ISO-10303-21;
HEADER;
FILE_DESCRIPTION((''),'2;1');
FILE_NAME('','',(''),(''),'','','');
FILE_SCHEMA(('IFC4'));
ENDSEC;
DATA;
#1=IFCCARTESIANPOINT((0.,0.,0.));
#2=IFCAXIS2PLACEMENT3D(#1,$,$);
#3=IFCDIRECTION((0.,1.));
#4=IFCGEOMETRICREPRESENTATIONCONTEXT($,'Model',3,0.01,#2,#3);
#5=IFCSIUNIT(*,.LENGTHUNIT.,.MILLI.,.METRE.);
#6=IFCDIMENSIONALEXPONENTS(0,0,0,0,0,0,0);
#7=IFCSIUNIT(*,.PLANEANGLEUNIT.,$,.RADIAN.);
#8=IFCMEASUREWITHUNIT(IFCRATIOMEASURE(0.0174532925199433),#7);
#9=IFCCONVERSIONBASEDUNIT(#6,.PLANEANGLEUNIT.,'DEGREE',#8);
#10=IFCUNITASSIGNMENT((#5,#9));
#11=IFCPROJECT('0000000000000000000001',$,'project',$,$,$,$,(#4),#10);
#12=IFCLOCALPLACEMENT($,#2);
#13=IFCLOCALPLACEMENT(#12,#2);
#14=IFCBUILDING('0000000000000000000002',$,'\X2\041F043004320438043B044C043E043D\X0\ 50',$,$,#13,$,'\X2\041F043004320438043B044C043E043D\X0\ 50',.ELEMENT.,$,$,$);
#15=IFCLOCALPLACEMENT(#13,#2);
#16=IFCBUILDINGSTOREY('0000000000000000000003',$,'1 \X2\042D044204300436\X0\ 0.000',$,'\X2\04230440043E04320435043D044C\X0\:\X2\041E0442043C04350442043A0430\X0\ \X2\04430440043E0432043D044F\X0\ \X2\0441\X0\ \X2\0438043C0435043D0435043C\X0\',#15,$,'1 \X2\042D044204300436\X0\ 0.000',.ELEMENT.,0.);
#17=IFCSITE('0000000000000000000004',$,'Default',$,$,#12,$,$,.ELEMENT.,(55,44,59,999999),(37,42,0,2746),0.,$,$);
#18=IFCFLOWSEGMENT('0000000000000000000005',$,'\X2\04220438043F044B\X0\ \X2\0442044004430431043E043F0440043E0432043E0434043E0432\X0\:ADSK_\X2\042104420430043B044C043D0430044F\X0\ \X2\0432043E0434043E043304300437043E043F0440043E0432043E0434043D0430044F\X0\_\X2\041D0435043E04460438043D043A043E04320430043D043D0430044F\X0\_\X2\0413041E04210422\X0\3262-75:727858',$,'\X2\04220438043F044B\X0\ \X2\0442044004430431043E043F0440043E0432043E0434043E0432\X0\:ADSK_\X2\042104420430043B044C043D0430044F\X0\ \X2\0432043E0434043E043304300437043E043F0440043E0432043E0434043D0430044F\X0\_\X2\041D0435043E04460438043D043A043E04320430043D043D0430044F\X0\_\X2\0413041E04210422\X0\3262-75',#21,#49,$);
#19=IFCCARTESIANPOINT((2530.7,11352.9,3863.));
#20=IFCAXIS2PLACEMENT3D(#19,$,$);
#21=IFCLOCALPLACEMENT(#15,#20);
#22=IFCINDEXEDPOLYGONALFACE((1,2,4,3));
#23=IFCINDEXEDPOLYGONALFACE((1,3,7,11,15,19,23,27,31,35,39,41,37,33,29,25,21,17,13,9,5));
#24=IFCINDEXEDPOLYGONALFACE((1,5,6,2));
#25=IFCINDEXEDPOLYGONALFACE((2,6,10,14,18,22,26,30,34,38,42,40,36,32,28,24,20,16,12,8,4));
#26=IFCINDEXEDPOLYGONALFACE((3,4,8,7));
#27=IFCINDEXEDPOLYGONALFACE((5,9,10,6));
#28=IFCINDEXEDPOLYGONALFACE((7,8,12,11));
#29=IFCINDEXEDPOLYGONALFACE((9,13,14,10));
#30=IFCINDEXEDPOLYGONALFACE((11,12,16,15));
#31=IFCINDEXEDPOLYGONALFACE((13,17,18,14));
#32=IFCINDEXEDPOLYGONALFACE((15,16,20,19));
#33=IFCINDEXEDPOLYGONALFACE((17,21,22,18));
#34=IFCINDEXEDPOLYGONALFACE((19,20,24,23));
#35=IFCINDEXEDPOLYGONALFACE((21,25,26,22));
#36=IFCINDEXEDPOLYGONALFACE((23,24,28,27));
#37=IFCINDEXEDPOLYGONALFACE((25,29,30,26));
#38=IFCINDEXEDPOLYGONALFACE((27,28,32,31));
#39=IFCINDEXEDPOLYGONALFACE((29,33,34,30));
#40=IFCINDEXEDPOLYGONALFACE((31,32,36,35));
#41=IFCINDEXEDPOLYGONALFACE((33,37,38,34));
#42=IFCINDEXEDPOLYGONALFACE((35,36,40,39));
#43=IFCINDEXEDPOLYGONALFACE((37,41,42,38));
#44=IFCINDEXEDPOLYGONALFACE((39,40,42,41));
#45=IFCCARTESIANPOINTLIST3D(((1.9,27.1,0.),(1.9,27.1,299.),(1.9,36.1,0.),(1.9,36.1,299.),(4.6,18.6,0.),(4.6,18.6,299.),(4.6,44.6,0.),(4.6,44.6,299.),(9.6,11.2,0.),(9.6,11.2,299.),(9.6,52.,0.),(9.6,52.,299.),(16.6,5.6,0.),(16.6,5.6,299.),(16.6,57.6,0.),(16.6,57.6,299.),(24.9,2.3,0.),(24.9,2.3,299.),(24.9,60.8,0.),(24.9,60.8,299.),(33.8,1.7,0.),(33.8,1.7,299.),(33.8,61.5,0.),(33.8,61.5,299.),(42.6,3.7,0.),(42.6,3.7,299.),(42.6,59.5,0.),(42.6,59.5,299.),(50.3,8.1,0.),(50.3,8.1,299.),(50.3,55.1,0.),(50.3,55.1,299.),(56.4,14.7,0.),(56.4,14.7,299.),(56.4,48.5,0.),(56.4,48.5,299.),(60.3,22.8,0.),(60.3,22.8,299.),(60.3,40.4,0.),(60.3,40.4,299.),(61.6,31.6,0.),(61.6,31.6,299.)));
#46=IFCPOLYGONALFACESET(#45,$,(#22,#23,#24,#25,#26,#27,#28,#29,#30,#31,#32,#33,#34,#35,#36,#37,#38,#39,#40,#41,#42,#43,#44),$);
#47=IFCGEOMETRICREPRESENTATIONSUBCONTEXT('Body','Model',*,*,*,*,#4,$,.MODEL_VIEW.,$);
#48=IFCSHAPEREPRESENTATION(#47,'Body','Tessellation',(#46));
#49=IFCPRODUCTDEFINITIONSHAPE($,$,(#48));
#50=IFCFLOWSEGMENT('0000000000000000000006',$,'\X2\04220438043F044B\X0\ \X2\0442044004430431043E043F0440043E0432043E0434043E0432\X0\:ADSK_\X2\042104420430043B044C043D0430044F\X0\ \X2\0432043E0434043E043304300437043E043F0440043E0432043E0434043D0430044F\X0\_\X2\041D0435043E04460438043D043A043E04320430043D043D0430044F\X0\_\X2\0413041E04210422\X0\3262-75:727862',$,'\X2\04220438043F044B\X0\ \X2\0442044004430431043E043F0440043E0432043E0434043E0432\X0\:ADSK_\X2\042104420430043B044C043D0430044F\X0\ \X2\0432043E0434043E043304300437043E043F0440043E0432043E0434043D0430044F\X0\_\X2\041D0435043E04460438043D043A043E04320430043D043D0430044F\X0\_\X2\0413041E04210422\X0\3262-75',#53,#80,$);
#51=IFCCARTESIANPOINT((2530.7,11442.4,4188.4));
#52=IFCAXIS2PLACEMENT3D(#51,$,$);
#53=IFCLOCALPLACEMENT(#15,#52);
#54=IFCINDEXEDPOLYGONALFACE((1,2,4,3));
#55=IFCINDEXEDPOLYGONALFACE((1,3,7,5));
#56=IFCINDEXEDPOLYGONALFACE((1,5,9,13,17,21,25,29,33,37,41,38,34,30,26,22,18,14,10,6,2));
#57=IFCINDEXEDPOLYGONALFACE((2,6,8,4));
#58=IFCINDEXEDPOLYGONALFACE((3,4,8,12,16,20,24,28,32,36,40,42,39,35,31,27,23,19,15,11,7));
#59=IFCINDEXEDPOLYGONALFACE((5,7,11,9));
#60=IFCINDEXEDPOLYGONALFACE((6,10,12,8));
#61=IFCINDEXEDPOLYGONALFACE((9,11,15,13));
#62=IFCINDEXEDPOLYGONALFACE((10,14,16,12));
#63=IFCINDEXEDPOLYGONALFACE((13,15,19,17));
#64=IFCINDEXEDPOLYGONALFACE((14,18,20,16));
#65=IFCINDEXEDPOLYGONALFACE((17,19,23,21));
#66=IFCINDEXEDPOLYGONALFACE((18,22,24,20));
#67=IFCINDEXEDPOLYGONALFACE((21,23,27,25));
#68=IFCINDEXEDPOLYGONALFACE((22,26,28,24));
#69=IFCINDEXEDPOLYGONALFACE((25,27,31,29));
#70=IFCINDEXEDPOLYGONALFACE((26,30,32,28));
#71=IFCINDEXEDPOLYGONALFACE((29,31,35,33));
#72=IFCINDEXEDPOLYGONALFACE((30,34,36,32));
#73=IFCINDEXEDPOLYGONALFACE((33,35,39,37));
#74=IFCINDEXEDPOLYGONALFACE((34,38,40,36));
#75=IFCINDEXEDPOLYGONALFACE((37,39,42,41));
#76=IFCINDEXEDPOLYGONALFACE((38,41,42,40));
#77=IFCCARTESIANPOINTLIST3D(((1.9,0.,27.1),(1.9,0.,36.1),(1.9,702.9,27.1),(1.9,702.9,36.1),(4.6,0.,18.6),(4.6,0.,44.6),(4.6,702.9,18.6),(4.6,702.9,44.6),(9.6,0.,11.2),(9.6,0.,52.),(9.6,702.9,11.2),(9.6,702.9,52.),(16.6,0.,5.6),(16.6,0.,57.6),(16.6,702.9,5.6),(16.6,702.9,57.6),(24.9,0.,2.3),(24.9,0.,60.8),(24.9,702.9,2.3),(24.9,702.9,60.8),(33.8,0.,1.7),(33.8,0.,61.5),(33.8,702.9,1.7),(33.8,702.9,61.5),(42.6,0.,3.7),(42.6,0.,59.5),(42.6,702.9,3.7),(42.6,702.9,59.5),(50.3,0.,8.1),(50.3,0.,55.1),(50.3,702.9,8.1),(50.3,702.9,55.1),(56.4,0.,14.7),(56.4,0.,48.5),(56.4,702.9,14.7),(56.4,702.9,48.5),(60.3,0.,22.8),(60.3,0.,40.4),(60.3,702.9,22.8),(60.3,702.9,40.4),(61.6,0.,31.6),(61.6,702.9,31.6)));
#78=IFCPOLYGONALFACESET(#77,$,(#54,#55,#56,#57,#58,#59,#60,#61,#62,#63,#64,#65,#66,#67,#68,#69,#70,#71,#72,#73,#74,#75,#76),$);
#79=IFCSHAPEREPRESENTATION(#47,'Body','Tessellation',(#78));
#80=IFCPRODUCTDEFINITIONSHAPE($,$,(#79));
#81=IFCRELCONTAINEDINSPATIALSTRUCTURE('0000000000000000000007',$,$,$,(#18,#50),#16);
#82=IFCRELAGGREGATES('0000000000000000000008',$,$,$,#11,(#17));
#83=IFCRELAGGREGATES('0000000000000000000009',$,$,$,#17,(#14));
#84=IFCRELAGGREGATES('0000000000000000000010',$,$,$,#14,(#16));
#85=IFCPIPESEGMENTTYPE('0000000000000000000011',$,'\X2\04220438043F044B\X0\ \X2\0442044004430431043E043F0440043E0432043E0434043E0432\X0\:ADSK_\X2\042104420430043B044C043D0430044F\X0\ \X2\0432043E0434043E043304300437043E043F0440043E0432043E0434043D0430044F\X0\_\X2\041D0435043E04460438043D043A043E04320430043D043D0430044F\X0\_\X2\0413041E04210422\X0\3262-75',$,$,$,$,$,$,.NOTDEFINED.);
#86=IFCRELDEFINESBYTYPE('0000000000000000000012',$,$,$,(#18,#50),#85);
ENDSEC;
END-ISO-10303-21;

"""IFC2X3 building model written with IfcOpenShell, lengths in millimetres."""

from ifc_helpers import new_model, entity, si_unit, converted_unit, direction, frame, origin, origin_2d_with_axis, place, context, subcontext, project, spatial, circle, extrude, type_object, element, save


model = new_model("IFC2X3")

# Units and contexts
model_context = context("Model", 3, precision=0.01, world=origin(), true_north=direction((0.0, 1.0)))
body_context = subcontext(model_context, "Body", "Model", "MODEL_VIEW")
ifc_project = project(units=[si_unit("LENGTHUNIT", "METRE", prefix="MILLI"), converted_unit("PLANEANGLEUNIT", "DEGREE", entity("IfcRatioMeasure", 0.0174532925199433), si_unit("PLANEANGLEUNIT", "RADIAN"), dimensions=[0, 0, 0, 0, 0, 0, 0])], contexts=[model_context])

# Site, building, storey
site_placement = place(None, origin())
site = spatial("IfcSite", under=ifc_project, at=site_placement, Name="Default", CompositionType="ELEMENT", RefLatitude=(55, 44, 59, 999999), RefLongitude=(37, 42, 0, 2746), RefElevation=0.0)
building_placement = place(site_placement, origin())
building = spatial("IfcBuilding", under=site, at=building_placement, Name="Павильон 50", LongName="Павильон 50", CompositionType="ELEMENT")
storey_placement = place(building_placement, origin())
storey = spatial("IfcBuildingStorey", under=building, at=storey_placement, Name="1 Этаж 0.000", ObjectType="Уровень:Отметка уровня с именем", LongName="1 Этаж 0.000", CompositionType="ELEMENT", Elevation=0.0)

# Flow segments
pipe_segment_type = type_object("IfcPipeSegmentType", Name="Типы трубопроводов:ADSK_Стальная водогазопроводная_Неоцинкованная_ГОСТ3262-75", PredefinedType="NOTDEFINED")
flow_segment_1_placement = place(storey_placement, frame((2530.7, 11352.9, 3863.0)))
element("IfcFlowSegment", 1, at=flow_segment_1_placement, inside=storey, type_object=pipe_segment_type, Name="Типы трубопроводов:ADSK_Стальная водогазопроводная_Неоцинкованная_ГОСТ3262-75:727858", ObjectType="Типы трубопроводов:ADSK_Стальная водогазопроводная_Неоцинкованная_ГОСТ3262-75", context=body_context, shape_type="SweptSolid", body=[
    extrude(circle(Radius=30.0, at=origin_2d_with_axis()), frame((31.6, 31.6, 0.0)), (0.0, 0.0, 1.0), 299.0),
])
flow_segment_2_placement = place(storey_placement, frame((2530.7, 11442.4, 4188.4)))
element("IfcFlowSegment", 2, at=flow_segment_2_placement, inside=storey, type_object=pipe_segment_type, Name="Типы трубопроводов:ADSK_Стальная водогазопроводная_Неоцинкованная_ГОСТ3262-75:727862", ObjectType="Типы трубопроводов:ADSK_Стальная водогазопроводная_Неоцинкованная_ГОСТ3262-75", context=body_context, shape_type="SweptSolid", body=[
    extrude(circle(Radius=30.0, at=origin_2d_with_axis()), frame((31.6, 0.0, 31.6), z_axis=(0.0, 1.0, 0.0), x_axis=(1.0, 0.0, 0.0)), (0.0, 0.0, 1.0), 702.9),
])

save(model, "model.ifc")
